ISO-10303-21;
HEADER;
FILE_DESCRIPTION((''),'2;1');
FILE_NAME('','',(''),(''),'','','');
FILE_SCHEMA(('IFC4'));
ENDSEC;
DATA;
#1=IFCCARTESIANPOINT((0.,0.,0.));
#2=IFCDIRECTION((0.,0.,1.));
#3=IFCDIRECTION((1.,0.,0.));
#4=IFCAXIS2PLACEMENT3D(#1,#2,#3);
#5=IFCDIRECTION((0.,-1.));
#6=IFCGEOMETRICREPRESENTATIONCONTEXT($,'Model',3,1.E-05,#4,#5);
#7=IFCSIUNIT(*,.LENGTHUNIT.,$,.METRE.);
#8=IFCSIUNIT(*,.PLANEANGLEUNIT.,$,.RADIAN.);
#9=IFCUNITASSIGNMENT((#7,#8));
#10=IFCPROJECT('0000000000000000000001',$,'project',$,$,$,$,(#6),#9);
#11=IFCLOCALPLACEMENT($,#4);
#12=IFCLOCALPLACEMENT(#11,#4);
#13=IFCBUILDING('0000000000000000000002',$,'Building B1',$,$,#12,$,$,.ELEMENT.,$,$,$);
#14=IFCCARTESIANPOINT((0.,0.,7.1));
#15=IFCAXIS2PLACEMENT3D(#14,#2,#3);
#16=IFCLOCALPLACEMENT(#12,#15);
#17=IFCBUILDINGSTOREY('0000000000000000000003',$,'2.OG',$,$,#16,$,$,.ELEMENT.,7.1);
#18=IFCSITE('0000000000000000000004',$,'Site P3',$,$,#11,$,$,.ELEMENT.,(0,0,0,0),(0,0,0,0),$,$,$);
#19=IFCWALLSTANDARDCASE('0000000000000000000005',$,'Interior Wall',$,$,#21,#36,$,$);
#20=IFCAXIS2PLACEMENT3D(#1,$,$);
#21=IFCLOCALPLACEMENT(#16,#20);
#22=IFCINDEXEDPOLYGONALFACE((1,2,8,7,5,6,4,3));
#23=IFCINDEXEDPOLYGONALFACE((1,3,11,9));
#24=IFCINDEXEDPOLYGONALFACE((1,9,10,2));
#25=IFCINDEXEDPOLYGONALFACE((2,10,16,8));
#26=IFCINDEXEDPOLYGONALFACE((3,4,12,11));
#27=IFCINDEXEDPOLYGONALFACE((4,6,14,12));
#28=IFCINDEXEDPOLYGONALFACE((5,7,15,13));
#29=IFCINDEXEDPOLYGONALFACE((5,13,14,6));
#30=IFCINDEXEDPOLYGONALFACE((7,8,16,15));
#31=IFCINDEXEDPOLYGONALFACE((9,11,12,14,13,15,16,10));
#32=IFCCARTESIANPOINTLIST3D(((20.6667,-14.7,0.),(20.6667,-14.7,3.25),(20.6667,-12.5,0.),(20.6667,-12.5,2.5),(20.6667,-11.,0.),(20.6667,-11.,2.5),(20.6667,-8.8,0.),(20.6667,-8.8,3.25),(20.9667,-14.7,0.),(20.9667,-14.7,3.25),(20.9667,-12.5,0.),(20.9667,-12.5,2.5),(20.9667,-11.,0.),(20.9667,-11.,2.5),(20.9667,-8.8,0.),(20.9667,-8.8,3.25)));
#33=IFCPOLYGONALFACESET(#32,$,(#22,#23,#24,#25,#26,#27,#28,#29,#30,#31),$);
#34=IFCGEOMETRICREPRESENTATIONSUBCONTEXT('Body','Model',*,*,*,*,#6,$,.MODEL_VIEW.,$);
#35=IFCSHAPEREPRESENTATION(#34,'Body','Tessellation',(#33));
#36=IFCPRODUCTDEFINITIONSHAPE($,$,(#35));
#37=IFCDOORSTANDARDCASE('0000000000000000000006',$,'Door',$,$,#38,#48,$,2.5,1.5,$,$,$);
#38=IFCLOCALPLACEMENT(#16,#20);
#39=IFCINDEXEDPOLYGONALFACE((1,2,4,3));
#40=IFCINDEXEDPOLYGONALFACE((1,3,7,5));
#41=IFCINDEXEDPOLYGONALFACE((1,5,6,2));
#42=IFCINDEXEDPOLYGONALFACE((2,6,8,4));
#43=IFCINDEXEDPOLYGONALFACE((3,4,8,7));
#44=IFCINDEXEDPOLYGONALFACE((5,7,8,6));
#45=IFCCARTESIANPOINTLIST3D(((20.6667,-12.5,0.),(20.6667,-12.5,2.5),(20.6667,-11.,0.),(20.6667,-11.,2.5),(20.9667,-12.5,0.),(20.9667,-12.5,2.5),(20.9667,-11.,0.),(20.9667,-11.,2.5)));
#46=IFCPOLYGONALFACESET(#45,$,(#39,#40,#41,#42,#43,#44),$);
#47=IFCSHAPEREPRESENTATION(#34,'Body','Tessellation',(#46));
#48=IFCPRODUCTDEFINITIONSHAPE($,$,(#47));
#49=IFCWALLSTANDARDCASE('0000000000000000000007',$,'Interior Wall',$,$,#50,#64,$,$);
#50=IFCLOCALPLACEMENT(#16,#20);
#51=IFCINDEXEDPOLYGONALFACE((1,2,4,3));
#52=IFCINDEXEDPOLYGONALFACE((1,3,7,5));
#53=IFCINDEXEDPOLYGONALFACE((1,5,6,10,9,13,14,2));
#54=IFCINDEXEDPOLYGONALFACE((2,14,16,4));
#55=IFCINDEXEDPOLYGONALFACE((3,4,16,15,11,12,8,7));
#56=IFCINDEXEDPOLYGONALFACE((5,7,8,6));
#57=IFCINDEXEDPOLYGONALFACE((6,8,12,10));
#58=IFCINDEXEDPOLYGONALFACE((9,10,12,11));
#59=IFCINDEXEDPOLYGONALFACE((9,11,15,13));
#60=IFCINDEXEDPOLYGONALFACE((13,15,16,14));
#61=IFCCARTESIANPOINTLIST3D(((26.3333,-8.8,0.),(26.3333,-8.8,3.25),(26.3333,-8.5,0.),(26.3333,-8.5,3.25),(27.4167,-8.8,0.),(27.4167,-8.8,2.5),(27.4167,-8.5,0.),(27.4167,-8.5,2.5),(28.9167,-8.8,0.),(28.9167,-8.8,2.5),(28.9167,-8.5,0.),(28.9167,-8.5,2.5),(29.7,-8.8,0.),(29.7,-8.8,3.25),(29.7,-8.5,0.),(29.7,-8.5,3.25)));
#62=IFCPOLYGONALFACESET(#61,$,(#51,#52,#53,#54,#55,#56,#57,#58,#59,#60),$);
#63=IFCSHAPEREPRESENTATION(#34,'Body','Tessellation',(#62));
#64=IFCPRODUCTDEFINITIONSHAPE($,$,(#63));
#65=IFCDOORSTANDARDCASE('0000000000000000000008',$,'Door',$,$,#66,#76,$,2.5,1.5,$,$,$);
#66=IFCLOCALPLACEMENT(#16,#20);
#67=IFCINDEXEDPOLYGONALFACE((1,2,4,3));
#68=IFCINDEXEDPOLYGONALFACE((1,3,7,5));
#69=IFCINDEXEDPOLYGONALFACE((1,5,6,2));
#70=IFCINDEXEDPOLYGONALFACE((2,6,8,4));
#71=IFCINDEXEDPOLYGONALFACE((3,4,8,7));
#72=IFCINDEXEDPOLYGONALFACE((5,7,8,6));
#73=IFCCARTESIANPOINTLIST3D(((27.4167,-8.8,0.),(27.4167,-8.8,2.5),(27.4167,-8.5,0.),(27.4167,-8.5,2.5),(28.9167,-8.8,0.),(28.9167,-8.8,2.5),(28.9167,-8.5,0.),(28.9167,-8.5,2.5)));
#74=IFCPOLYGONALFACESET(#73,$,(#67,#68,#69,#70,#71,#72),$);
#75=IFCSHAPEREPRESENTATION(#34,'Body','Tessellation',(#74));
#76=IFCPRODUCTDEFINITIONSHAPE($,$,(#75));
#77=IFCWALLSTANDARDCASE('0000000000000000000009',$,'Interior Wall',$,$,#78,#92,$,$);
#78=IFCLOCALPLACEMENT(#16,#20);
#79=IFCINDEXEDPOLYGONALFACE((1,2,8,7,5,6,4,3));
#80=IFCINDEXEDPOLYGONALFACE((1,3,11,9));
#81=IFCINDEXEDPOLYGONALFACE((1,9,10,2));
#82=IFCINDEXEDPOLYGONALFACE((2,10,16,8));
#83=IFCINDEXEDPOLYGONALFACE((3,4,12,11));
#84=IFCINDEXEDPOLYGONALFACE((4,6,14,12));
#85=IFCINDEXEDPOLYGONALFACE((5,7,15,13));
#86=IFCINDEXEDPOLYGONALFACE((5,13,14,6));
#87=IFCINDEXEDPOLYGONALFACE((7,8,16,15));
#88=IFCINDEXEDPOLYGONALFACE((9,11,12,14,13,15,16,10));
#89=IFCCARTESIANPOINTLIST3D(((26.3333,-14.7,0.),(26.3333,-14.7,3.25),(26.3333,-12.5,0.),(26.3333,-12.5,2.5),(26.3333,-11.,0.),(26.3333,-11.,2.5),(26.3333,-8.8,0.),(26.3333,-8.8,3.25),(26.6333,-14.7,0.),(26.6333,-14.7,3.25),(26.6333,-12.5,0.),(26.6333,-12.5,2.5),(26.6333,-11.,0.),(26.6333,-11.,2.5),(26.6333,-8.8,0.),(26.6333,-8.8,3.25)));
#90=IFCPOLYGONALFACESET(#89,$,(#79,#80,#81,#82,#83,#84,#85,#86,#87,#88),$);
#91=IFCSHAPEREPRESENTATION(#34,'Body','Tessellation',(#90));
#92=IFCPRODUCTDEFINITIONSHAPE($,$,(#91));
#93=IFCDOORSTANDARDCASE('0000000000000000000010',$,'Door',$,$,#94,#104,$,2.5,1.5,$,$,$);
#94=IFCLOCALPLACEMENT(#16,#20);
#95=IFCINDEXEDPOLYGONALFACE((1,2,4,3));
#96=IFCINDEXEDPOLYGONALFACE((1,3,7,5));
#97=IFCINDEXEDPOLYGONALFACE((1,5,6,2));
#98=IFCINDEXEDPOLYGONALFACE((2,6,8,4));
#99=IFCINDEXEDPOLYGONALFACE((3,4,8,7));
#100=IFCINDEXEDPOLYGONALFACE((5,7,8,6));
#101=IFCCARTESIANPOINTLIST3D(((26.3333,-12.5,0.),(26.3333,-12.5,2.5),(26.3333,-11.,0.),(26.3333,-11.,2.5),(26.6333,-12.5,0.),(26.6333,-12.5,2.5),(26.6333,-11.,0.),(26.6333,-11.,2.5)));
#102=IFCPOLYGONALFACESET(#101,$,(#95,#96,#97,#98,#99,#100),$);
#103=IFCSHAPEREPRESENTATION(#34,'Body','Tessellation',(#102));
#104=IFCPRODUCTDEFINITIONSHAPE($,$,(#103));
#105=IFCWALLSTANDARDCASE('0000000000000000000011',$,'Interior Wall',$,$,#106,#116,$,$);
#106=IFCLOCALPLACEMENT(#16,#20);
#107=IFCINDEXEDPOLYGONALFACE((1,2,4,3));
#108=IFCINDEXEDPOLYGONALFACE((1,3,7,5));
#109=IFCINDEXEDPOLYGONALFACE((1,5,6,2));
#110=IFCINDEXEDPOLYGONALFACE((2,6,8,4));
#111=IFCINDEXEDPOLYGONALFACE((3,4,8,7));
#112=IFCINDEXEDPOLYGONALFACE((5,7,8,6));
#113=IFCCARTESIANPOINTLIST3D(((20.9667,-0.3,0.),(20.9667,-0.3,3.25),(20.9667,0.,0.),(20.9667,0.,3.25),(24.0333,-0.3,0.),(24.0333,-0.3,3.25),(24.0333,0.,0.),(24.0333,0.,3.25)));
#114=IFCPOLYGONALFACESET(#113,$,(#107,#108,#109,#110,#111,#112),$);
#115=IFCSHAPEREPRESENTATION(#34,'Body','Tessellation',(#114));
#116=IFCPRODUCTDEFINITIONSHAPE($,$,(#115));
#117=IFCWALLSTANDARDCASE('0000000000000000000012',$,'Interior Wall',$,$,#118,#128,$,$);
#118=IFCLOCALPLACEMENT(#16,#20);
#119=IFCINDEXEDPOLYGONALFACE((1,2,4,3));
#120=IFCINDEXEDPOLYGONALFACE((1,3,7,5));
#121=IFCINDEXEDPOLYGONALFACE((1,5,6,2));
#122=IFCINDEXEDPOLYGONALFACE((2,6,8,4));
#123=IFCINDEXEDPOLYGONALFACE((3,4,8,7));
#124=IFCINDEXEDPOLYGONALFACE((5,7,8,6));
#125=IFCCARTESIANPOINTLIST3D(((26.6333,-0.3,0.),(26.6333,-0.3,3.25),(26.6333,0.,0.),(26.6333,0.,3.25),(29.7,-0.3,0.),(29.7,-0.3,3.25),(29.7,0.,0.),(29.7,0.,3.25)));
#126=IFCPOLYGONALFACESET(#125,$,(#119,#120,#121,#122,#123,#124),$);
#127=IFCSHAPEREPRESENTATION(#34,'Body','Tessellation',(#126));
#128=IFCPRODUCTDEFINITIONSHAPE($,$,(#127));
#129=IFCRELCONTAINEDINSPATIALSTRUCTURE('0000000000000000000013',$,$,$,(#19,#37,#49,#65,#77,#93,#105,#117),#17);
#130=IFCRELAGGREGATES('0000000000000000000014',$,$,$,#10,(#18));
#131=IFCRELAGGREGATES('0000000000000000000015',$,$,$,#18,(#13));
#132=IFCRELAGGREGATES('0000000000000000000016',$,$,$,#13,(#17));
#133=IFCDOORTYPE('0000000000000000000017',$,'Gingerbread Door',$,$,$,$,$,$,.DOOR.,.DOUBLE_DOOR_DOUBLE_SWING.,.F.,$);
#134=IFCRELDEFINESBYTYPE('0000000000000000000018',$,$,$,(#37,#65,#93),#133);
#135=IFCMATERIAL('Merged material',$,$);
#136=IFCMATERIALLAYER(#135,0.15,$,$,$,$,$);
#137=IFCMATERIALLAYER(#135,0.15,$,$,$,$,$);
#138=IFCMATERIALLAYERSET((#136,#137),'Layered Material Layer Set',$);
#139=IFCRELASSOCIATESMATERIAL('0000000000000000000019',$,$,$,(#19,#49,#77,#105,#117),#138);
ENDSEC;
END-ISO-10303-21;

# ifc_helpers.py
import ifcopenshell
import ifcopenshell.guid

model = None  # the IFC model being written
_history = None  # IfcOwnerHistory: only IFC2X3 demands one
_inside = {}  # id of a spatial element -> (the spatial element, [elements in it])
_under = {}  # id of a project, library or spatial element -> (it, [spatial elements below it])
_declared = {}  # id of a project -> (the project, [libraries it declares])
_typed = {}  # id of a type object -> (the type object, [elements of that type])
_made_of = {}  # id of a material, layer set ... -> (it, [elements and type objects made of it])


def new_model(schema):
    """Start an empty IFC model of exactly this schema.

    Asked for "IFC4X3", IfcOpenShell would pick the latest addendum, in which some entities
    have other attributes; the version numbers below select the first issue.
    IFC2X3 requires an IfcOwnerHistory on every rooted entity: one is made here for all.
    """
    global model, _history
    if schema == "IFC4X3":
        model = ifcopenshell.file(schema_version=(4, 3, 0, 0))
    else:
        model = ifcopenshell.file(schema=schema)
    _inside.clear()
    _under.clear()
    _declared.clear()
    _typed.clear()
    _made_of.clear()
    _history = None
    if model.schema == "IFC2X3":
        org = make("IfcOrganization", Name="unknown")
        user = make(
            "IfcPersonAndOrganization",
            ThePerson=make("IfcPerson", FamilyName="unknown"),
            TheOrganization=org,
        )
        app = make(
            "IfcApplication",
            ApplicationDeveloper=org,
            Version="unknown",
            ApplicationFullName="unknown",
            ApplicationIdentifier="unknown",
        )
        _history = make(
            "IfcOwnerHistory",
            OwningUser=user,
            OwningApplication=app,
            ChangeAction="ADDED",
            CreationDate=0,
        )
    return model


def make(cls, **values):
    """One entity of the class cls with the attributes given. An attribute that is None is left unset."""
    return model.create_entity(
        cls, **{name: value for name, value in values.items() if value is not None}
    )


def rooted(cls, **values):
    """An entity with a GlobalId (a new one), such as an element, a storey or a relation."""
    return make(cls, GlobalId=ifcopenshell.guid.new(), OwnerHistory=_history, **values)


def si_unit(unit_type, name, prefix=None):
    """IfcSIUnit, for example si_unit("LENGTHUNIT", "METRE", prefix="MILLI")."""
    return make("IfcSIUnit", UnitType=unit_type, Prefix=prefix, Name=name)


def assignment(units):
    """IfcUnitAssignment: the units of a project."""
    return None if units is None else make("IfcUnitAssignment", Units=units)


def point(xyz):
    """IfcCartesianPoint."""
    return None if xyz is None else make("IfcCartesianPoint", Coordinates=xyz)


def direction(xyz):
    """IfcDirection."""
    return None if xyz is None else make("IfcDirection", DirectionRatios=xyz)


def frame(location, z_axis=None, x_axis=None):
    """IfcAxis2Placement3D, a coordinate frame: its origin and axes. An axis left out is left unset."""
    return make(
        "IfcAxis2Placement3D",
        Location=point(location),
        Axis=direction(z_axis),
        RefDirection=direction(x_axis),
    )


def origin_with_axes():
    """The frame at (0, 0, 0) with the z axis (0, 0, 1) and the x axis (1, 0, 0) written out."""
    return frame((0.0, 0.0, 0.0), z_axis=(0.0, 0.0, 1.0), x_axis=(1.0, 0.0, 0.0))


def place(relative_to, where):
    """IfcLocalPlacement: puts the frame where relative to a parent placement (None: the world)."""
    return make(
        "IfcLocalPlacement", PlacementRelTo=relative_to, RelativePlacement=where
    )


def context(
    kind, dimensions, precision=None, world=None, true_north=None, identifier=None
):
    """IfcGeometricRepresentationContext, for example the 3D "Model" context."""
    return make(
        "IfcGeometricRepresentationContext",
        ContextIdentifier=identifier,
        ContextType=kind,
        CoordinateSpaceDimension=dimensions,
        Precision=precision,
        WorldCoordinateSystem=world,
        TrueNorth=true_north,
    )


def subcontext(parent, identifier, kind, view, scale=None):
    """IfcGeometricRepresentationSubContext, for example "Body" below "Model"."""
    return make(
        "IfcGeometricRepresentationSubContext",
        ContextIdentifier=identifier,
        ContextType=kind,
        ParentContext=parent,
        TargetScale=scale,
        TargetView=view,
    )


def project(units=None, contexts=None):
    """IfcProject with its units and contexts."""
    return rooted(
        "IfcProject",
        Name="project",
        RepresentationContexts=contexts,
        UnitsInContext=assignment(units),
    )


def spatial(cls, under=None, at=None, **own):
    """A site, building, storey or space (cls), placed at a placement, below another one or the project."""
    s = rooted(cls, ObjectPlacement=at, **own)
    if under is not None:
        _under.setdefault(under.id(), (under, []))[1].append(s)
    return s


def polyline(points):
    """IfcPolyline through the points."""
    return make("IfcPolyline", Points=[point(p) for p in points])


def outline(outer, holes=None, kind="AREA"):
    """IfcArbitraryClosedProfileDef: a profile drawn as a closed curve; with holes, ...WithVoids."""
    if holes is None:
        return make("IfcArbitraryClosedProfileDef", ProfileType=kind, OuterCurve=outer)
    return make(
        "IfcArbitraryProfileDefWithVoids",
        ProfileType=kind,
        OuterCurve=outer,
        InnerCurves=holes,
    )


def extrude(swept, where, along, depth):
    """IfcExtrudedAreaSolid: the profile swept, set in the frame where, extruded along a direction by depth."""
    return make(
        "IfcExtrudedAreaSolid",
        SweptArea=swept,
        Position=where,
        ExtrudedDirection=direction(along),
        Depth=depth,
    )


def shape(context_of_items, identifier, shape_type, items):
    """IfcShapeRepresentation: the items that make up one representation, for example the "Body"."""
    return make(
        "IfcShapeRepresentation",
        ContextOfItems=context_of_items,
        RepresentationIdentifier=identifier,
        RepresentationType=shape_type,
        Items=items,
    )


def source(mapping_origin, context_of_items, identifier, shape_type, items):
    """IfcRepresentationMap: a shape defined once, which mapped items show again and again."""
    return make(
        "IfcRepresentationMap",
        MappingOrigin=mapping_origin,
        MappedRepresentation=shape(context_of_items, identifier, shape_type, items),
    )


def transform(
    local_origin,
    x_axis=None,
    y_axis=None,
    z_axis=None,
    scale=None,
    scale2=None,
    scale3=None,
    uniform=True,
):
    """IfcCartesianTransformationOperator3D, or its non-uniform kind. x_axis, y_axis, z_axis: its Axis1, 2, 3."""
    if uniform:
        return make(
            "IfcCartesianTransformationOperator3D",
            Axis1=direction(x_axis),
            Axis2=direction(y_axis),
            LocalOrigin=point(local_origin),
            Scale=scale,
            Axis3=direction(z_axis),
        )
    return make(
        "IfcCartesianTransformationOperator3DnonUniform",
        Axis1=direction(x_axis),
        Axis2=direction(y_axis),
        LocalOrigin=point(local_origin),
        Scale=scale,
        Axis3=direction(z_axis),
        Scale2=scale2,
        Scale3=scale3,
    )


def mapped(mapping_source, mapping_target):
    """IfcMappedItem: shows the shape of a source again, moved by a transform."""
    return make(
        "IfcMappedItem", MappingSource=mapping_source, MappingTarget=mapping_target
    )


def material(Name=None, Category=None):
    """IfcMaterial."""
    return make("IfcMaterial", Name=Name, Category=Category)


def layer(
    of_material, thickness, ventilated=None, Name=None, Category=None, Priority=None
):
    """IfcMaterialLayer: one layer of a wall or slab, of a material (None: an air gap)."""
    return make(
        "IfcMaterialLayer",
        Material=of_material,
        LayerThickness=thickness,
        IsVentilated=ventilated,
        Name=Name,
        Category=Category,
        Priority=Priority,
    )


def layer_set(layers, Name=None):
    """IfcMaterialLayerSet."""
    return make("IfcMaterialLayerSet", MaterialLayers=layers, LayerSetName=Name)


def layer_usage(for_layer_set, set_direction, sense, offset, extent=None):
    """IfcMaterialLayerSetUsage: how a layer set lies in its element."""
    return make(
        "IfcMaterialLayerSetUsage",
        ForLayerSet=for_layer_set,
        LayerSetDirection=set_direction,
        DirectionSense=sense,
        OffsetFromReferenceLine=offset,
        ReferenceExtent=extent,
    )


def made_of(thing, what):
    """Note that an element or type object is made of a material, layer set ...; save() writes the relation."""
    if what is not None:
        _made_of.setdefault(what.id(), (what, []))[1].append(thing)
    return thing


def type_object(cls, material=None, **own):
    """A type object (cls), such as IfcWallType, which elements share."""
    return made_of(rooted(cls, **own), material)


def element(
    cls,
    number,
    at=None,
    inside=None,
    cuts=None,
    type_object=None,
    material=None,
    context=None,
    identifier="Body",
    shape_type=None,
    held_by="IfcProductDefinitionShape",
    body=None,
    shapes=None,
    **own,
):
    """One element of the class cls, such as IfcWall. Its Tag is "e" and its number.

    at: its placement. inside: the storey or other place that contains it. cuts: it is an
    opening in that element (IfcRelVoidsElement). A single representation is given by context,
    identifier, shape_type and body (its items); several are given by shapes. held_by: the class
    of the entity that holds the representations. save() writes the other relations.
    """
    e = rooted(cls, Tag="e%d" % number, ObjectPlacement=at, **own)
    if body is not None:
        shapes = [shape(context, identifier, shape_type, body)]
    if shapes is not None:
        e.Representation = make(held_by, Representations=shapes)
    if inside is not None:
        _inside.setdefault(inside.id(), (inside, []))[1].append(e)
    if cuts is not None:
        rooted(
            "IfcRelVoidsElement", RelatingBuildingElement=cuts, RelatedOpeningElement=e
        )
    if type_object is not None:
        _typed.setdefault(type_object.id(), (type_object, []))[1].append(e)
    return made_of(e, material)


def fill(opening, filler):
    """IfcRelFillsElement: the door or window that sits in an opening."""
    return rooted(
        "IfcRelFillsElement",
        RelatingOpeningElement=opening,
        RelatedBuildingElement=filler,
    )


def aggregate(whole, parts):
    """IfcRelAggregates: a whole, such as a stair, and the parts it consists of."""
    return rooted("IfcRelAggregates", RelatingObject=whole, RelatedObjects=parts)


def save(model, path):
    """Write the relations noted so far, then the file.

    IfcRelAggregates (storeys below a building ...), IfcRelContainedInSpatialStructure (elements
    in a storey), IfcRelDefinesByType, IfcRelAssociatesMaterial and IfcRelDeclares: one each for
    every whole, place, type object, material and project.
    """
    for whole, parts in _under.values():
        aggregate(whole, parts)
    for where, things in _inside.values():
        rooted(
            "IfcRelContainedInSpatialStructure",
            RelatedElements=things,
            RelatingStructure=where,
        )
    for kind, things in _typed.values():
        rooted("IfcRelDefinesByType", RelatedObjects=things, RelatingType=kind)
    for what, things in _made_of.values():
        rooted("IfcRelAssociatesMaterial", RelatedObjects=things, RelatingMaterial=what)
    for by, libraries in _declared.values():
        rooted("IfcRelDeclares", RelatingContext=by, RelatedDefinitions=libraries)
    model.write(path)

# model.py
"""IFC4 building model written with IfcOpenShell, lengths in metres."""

from ifc_helpers import new_model, si_unit, direction, frame, origin_with_axes, place, context, subcontext, project, spatial, polyline, outline, extrude, source, transform, mapped, material, layer, layer_set, layer_usage, type_object, element, fill, save


model = new_model("IFC4")

# Units and contexts
model_context = context("Model", 3, precision=1e-05, world=origin_with_axes(), true_north=direction((0.0, -1.0)))
body_context = subcontext(model_context, "Body", "Model", "MODEL_VIEW")
ifc_project = project(units=[si_unit("LENGTHUNIT", "METRE"), si_unit("PLANEANGLEUNIT", "RADIAN")], contexts=[model_context])

# Site, building, storey
site_placement = place(None, origin_with_axes())
site = spatial("IfcSite", under=ifc_project, at=site_placement, Name="Site P3", CompositionType="ELEMENT", RefLatitude=(0, 0, 0, 0), RefLongitude=(0, 0, 0, 0))
building_placement = place(site_placement, origin_with_axes())
building = spatial("IfcBuilding", under=site, at=building_placement, Name="Building B1", CompositionType="ELEMENT")
storey_placement = place(building_placement, frame((0.0, 0.0, 7.1), z_axis=(0.0, 0.0, 1.0), x_axis=(1.0, 0.0, 0.0)))
storey = spatial("IfcBuildingStorey", under=building, at=storey_placement, Name="2.OG", CompositionType="ELEMENT", Elevation=7.1)

# Shared definitions
ifc_material = material(Name="Merged material")

# Walls, openings, doors
ifc_layer_1 = layer(ifc_material, 0.15)
ifc_layer_2 = layer(ifc_material, 0.15)
ifc_layer_set_1 = layer_set([ifc_layer_1, ifc_layer_2], Name="Layered Material Layer Set")
ifc_layer_usage_1 = layer_usage(ifc_layer_set_1, "AXIS2", "POSITIVE", -0.15)
door_type = type_object("IfcDoorType", Name="Gingerbread Door", OperationType="DOUBLE_DOOR_DOUBLE_SWING", ParameterTakesPrecedence=False, PredefinedType="DOOR")
shared_shape_1 = source(origin_with_axes(), body_context, "Body", "SweptSolid", [
    extrude(outline(polyline([(0.0, 0.0), (0.0, 1.5), (2.5, 1.5), (2.5, 0.0), (0.0, 0.0)])), frame((0.0, -0.15, 0.0), z_axis=(0.0, 1.0, 0.0), x_axis=(0.0, 0.0, 1.0)), (0.0, 0.0, 1.0), 0.3),
])
wall_1_placement = place(storey_placement, frame((20.8167, -8.8, 0.0), z_axis=(0.0, 0.0, 1.0), x_axis=(0.0, -1.0, 0.0)))
wall_1 = element("IfcWallStandardCase", 1, at=wall_1_placement, inside=storey, material=ifc_layer_usage_1, Name="Interior Wall", context=body_context, shape_type="SweptSolid", body=[
    extrude(outline(polyline([(0.0, 0.15), (5.9, 0.15), (5.9, -0.15), (0.0, -0.15), (0.0, 0.15)])), origin_with_axes(), (0.0, 0.0, 1.0), 3.25),
])
opening_1_placement = place(wall_1_placement, frame((2.2, 0.0, 0.0), z_axis=(0.0, 0.0, 1.0), x_axis=(1.0, 0.0, 0.0)))
opening_1 = element("IfcOpeningStandardCase", 2, at=opening_1_placement, cuts=wall_1, context=body_context, shape_type="SweptSolid", body=[
    extrude(outline(polyline([(0.0, 0.0), (0.0, 1.5), (2.5, 1.5), (2.5, 0.0), (0.0, 0.0)])), frame((0.0, -0.15, 0.0), z_axis=(0.0, 1.0, 0.0), x_axis=(0.0, 0.0, 1.0)), (0.0, 0.0, 1.0), 0.3),
])
door_1_placement = place(opening_1_placement, origin_with_axes())
door_1 = element("IfcDoorStandardCase", 3, at=door_1_placement, inside=storey, type_object=door_type, Name="Door", OverallHeight=2.5, OverallWidth=1.5, context=body_context, shape_type="MappedRepresentation", body=[
    mapped(shared_shape_1, transform((0.0, 0.0, 0.0))),
])
fill(opening_1, door_1)
wall_2_placement = place(storey_placement, frame((26.3333, -8.65, 0.0), z_axis=(0.0, 0.0, 1.0), x_axis=(1.0, 0.0, 0.0)))
wall_2 = element("IfcWallStandardCase", 4, at=wall_2_placement, inside=storey, material=ifc_layer_usage_1, Name="Interior Wall", context=body_context, shape_type="SweptSolid", body=[
    extrude(outline(polyline([(0.0, 0.15), (3.3667, 0.15), (3.3667, -0.15), (0.0, -0.15), (0.0, 0.15)])), origin_with_axes(), (0.0, 0.0, 1.0), 3.25),
])
opening_2_placement = place(wall_2_placement, frame((1.0833, 0.0, 0.0), z_axis=(0.0, 0.0, 1.0), x_axis=(1.0, 0.0, 0.0)))
opening_2 = element("IfcOpeningStandardCase", 5, at=opening_2_placement, cuts=wall_2, context=body_context, shape_type="SweptSolid", body=[
    extrude(outline(polyline([(0.0, 0.0), (0.0, 1.5), (2.5, 1.5), (2.5, 0.0), (0.0, 0.0)])), frame((0.0, -0.15, 0.0), z_axis=(0.0, 1.0, 0.0), x_axis=(0.0, 0.0, 1.0)), (0.0, 0.0, 1.0), 0.3),
])
door_2_placement = place(opening_2_placement, origin_with_axes())
door_2 = element("IfcDoorStandardCase", 6, at=door_2_placement, inside=storey, type_object=door_type, Name="Door", OverallHeight=2.5, OverallWidth=1.5, context=body_context, shape_type="MappedRepresentation", body=[
    mapped(shared_shape_1, transform((0.0, 0.0, 0.0))),
])
fill(opening_2, door_2)
wall_3_placement = place(storey_placement, frame((26.4833, -8.8, 0.0), z_axis=(0.0, 0.0, 1.0), x_axis=(0.0, -1.0, 0.0)))
wall_3 = element("IfcWallStandardCase", 7, at=wall_3_placement, inside=storey, material=ifc_layer_usage_1, Name="Interior Wall", context=body_context, shape_type="SweptSolid", body=[
    extrude(outline(polyline([(0.0, 0.15), (5.9, 0.15), (5.9, -0.15), (0.0, -0.15), (0.0, 0.15)])), origin_with_axes(), (0.0, 0.0, 1.0), 3.25),
])
opening_3_placement = place(wall_3_placement, frame((2.2, 0.0, 0.0), z_axis=(0.0, 0.0, 1.0), x_axis=(1.0, 0.0, 0.0)))
opening_3 = element("IfcOpeningStandardCase", 8, at=opening_3_placement, cuts=wall_3, context=body_context, shape_type="SweptSolid", body=[
    extrude(outline(polyline([(0.0, 0.0), (0.0, 1.5), (2.5, 1.5), (2.5, 0.0), (0.0, 0.0)])), frame((0.0, -0.15, 0.0), z_axis=(0.0, 1.0, 0.0), x_axis=(0.0, 0.0, 1.0)), (0.0, 0.0, 1.0), 0.3),
])
door_3_placement = place(opening_3_placement, origin_with_axes())
door_3 = element("IfcDoorStandardCase", 9, at=door_3_placement, inside=storey, type_object=door_type, Name="Door", OverallHeight=2.5, OverallWidth=1.5, context=body_context, shape_type="MappedRepresentation", body=[
    mapped(shared_shape_1, transform((0.0, 0.0, 0.0))),
])
fill(opening_3, door_3)

# Walls
wall_4_placement = place(storey_placement, frame((20.9667, -0.15, 0.0), z_axis=(0.0, 0.0, 1.0), x_axis=(1.0, 0.0, 0.0)))
element("IfcWallStandardCase", 10, at=wall_4_placement, inside=storey, material=ifc_layer_usage_1, Name="Interior Wall", context=body_context, shape_type="SweptSolid", body=[
    extrude(outline(polyline([(0.0, 0.15), (3.0667, 0.15), (3.0667, -0.15), (0.0, -0.15), (0.0, 0.15)])), origin_with_axes(), (0.0, 0.0, 1.0), 3.25),
])
wall_5_placement = place(storey_placement, frame((26.6333, -0.15, 0.0), z_axis=(0.0, 0.0, 1.0), x_axis=(1.0, 0.0, 0.0)))
element("IfcWallStandardCase", 11, at=wall_5_placement, inside=storey, material=ifc_layer_usage_1, Name="Interior Wall", context=body_context, shape_type="SweptSolid", body=[
    extrude(outline(polyline([(0.0, 0.15), (3.0667, 0.15), (3.0667, -0.15), (0.0, -0.15), (0.0, 0.15)])), origin_with_axes(), (0.0, 0.0, 1.0), 3.25),
])

save(model, "model.ifc")
